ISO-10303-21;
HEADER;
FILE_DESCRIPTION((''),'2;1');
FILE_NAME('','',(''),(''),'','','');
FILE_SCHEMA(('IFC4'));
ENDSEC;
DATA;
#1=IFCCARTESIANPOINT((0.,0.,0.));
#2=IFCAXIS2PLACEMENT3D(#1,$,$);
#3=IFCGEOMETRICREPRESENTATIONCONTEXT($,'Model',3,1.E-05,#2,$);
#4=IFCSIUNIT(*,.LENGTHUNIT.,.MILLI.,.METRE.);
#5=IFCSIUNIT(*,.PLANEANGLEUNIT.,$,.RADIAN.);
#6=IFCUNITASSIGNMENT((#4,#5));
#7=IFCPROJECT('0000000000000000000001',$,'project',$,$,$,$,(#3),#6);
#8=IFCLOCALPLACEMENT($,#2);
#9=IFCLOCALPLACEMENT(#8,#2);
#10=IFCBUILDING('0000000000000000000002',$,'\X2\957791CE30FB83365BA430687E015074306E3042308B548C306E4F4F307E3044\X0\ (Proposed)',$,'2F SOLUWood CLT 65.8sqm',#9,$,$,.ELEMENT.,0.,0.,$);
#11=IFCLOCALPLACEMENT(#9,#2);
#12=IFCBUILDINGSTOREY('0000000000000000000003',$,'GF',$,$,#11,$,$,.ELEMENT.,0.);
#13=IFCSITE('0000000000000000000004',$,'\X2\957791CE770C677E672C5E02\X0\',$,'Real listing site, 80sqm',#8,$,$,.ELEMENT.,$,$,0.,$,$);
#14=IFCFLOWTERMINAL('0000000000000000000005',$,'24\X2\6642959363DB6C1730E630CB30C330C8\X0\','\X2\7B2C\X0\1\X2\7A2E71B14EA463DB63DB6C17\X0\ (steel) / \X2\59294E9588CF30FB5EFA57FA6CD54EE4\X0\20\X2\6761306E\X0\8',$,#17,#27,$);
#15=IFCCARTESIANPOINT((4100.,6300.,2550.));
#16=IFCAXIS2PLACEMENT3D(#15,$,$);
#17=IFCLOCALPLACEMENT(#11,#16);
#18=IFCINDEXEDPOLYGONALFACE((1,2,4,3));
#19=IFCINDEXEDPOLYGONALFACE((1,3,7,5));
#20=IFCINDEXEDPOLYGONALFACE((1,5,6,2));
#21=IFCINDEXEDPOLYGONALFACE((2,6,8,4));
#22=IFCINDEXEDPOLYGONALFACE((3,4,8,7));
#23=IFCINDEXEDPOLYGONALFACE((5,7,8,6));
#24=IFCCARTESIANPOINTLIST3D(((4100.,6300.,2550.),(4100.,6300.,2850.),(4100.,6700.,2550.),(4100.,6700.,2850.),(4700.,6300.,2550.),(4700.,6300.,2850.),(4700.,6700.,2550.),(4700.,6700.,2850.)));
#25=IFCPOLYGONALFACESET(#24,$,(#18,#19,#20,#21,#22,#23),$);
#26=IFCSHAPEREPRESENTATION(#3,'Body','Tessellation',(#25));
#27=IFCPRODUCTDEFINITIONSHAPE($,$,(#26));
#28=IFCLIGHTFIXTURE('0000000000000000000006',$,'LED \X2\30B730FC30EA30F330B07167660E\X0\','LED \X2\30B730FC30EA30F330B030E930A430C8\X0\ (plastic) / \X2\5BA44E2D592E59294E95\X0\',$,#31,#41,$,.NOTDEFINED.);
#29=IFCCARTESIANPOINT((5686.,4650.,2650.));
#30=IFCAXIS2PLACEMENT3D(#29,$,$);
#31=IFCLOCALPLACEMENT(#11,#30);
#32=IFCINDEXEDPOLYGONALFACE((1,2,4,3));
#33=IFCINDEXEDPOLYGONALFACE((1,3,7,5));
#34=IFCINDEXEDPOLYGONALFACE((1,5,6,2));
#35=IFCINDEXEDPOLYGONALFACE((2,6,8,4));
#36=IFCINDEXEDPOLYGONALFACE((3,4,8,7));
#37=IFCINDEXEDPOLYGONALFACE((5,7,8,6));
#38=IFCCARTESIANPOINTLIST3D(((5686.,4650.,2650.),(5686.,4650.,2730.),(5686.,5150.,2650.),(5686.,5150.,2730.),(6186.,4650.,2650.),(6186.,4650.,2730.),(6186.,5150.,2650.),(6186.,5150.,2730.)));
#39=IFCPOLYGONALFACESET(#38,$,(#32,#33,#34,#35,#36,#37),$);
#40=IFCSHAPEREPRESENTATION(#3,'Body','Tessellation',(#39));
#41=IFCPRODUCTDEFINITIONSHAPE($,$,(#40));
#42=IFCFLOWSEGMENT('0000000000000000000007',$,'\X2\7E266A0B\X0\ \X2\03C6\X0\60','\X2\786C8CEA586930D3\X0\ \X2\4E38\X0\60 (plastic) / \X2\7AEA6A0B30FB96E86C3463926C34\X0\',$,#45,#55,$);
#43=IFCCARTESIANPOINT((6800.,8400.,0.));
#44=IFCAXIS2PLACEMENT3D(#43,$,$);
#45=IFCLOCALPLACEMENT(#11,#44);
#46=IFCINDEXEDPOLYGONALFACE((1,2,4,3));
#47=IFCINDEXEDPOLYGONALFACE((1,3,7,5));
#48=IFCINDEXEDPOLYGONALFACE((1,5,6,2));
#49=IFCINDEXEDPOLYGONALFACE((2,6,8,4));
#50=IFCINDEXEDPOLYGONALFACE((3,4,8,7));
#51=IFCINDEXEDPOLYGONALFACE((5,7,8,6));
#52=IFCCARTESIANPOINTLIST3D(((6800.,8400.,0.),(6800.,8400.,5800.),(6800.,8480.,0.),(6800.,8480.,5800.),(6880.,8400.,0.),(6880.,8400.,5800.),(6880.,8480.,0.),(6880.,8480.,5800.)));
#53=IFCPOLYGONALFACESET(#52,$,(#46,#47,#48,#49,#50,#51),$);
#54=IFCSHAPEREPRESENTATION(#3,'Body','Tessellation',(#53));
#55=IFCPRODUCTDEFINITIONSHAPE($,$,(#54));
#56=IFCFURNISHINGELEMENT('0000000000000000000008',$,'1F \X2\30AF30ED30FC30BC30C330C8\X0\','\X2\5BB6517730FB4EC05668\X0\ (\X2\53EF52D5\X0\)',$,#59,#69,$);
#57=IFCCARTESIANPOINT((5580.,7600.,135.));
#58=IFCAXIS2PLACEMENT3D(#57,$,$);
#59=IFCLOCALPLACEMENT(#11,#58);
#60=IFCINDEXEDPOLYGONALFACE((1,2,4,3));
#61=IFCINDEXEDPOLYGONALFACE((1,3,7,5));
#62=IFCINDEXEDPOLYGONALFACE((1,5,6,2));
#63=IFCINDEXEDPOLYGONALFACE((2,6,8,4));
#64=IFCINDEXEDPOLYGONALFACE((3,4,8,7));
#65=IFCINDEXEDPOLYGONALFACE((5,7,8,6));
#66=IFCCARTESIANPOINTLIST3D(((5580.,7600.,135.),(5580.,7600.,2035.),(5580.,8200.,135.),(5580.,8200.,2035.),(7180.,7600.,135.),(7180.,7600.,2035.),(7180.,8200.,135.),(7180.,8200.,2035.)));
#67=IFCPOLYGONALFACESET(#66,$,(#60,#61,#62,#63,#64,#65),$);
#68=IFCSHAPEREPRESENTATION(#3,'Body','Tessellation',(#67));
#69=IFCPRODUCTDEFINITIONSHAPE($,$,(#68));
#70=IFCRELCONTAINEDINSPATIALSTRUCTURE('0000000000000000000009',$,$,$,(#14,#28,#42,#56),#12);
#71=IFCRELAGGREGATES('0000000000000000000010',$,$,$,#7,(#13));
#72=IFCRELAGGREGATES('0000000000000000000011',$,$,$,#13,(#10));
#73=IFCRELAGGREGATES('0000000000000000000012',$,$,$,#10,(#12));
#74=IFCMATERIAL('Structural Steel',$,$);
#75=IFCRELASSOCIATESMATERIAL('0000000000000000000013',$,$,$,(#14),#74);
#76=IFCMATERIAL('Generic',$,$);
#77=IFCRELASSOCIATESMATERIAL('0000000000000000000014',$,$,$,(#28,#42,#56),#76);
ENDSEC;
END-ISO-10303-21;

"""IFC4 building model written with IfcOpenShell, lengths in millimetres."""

from ifc_helpers import new_model, si_unit, frame, frame_2d, origin, place, context, project, spatial, rectangle, extrude, material, element, save


model = new_model("IFC4")

# Units and contexts
model_context = context("Model", 3, precision=1e-05, world=origin())
ifc_project = project(units=[si_unit("LENGTHUNIT", "METRE", prefix="MILLI"), si_unit("PLANEANGLEUNIT", "RADIAN")], contexts=[model_context])

# Site, building, storey
site_placement = place(None, origin())
site = spatial("IfcSite", under=ifc_project, at=site_placement, Name="長野県松本市", ObjectType="Real listing site, 80sqm", CompositionType="ELEMENT", RefElevation=0.0)
building_placement = place(site_placement, origin())
building = spatial("IfcBuilding", under=site, at=building_placement, Name="長野・茶室と縁側のある和の住まい (Proposed)", ObjectType="2F SOLUWood CLT 65.8sqm", CompositionType="ELEMENT", ElevationOfRefHeight=0.0, ElevationOfTerrain=0.0)
storey_placement = place(building_placement, origin())
storey = spatial("IfcBuildingStorey", under=building, at=storey_placement, Name="GF", CompositionType="ELEMENT", Elevation=0.0)

# Shared definitions
ifc_material_1 = material(Name="Generic")

# Flow terminal
ifc_material_2 = material(Name="Structural Steel")
flow_terminal_placement = place(storey_placement, frame((4100.0, 6300.0, 2550.0)))
element("IfcFlowTerminal", 1, at=flow_terminal_placement, inside=storey, material=ifc_material_2, Name="24時間換気ユニット", Description="第1種熱交換換気 (steel) / 天井裏・建基法令20条の8", context=model_context, shape_type="SweptSolid", body=[
    extrude(rectangle(XDim=600.0, YDim=400.0, at=frame_2d((300.0, 200.0))), frame((4100.0, 6300.0, 2550.0)), (0.0, 0.0, 1.0), 300.0),
])

# Light fixture
light_fixture_placement = place(storey_placement, frame((5686.0, 4650.0, 2650.0)))
element("IfcLightFixture", 2, at=light_fixture_placement, inside=storey, material=ifc_material_1, Name="LED シーリング照明", Description="LED シーリングライト (plastic) / 室中央天井", PredefinedType="NOTDEFINED", context=model_context, shape_type="SweptSolid", body=[
    extrude(rectangle(XDim=500.0, YDim=500.0, at=frame_2d((250.0, 250.0))), frame((5686.0, 4650.0, 2650.0)), (0.0, 0.0, 1.0), 80.0),
])

# Flow segment
flow_segment_placement = place(storey_placement, frame((6800.0, 8400.0, 0.0)))
element("IfcFlowSegment", 3, at=flow_segment_placement, inside=storey, material=ifc_material_1, Name="縦樋 φ60", Description="硬質塩ビ 丸60 (plastic) / 竪樋・雨水排水", context=model_context, shape_type="SweptSolid", body=[
    extrude(rectangle(XDim=80.0, YDim=80.0, at=frame_2d((40.0, 40.0))), frame((6800.0, 8400.0, 0.0)), (0.0, 0.0, 1.0), 5800.0),
])

# Furnishing element
furnishing_placement = place(storey_placement, frame((5580.0, 7600.0, 135.0)))
element("IfcFurnishingElement", 4, at=furnishing_placement, inside=storey, material=ifc_material_1, Name="1F クローゼット", Description="家具・什器 (可動)", context=model_context, shape_type="SweptSolid", body=[
    extrude(rectangle(XDim=1600.0, YDim=600.0, at=frame_2d((800.0, 300.0))), frame((5580.0, 7600.0, 135.0)), (0.0, 0.0, 1.0), 1900.0),
])

save(model, "model.ifc")
